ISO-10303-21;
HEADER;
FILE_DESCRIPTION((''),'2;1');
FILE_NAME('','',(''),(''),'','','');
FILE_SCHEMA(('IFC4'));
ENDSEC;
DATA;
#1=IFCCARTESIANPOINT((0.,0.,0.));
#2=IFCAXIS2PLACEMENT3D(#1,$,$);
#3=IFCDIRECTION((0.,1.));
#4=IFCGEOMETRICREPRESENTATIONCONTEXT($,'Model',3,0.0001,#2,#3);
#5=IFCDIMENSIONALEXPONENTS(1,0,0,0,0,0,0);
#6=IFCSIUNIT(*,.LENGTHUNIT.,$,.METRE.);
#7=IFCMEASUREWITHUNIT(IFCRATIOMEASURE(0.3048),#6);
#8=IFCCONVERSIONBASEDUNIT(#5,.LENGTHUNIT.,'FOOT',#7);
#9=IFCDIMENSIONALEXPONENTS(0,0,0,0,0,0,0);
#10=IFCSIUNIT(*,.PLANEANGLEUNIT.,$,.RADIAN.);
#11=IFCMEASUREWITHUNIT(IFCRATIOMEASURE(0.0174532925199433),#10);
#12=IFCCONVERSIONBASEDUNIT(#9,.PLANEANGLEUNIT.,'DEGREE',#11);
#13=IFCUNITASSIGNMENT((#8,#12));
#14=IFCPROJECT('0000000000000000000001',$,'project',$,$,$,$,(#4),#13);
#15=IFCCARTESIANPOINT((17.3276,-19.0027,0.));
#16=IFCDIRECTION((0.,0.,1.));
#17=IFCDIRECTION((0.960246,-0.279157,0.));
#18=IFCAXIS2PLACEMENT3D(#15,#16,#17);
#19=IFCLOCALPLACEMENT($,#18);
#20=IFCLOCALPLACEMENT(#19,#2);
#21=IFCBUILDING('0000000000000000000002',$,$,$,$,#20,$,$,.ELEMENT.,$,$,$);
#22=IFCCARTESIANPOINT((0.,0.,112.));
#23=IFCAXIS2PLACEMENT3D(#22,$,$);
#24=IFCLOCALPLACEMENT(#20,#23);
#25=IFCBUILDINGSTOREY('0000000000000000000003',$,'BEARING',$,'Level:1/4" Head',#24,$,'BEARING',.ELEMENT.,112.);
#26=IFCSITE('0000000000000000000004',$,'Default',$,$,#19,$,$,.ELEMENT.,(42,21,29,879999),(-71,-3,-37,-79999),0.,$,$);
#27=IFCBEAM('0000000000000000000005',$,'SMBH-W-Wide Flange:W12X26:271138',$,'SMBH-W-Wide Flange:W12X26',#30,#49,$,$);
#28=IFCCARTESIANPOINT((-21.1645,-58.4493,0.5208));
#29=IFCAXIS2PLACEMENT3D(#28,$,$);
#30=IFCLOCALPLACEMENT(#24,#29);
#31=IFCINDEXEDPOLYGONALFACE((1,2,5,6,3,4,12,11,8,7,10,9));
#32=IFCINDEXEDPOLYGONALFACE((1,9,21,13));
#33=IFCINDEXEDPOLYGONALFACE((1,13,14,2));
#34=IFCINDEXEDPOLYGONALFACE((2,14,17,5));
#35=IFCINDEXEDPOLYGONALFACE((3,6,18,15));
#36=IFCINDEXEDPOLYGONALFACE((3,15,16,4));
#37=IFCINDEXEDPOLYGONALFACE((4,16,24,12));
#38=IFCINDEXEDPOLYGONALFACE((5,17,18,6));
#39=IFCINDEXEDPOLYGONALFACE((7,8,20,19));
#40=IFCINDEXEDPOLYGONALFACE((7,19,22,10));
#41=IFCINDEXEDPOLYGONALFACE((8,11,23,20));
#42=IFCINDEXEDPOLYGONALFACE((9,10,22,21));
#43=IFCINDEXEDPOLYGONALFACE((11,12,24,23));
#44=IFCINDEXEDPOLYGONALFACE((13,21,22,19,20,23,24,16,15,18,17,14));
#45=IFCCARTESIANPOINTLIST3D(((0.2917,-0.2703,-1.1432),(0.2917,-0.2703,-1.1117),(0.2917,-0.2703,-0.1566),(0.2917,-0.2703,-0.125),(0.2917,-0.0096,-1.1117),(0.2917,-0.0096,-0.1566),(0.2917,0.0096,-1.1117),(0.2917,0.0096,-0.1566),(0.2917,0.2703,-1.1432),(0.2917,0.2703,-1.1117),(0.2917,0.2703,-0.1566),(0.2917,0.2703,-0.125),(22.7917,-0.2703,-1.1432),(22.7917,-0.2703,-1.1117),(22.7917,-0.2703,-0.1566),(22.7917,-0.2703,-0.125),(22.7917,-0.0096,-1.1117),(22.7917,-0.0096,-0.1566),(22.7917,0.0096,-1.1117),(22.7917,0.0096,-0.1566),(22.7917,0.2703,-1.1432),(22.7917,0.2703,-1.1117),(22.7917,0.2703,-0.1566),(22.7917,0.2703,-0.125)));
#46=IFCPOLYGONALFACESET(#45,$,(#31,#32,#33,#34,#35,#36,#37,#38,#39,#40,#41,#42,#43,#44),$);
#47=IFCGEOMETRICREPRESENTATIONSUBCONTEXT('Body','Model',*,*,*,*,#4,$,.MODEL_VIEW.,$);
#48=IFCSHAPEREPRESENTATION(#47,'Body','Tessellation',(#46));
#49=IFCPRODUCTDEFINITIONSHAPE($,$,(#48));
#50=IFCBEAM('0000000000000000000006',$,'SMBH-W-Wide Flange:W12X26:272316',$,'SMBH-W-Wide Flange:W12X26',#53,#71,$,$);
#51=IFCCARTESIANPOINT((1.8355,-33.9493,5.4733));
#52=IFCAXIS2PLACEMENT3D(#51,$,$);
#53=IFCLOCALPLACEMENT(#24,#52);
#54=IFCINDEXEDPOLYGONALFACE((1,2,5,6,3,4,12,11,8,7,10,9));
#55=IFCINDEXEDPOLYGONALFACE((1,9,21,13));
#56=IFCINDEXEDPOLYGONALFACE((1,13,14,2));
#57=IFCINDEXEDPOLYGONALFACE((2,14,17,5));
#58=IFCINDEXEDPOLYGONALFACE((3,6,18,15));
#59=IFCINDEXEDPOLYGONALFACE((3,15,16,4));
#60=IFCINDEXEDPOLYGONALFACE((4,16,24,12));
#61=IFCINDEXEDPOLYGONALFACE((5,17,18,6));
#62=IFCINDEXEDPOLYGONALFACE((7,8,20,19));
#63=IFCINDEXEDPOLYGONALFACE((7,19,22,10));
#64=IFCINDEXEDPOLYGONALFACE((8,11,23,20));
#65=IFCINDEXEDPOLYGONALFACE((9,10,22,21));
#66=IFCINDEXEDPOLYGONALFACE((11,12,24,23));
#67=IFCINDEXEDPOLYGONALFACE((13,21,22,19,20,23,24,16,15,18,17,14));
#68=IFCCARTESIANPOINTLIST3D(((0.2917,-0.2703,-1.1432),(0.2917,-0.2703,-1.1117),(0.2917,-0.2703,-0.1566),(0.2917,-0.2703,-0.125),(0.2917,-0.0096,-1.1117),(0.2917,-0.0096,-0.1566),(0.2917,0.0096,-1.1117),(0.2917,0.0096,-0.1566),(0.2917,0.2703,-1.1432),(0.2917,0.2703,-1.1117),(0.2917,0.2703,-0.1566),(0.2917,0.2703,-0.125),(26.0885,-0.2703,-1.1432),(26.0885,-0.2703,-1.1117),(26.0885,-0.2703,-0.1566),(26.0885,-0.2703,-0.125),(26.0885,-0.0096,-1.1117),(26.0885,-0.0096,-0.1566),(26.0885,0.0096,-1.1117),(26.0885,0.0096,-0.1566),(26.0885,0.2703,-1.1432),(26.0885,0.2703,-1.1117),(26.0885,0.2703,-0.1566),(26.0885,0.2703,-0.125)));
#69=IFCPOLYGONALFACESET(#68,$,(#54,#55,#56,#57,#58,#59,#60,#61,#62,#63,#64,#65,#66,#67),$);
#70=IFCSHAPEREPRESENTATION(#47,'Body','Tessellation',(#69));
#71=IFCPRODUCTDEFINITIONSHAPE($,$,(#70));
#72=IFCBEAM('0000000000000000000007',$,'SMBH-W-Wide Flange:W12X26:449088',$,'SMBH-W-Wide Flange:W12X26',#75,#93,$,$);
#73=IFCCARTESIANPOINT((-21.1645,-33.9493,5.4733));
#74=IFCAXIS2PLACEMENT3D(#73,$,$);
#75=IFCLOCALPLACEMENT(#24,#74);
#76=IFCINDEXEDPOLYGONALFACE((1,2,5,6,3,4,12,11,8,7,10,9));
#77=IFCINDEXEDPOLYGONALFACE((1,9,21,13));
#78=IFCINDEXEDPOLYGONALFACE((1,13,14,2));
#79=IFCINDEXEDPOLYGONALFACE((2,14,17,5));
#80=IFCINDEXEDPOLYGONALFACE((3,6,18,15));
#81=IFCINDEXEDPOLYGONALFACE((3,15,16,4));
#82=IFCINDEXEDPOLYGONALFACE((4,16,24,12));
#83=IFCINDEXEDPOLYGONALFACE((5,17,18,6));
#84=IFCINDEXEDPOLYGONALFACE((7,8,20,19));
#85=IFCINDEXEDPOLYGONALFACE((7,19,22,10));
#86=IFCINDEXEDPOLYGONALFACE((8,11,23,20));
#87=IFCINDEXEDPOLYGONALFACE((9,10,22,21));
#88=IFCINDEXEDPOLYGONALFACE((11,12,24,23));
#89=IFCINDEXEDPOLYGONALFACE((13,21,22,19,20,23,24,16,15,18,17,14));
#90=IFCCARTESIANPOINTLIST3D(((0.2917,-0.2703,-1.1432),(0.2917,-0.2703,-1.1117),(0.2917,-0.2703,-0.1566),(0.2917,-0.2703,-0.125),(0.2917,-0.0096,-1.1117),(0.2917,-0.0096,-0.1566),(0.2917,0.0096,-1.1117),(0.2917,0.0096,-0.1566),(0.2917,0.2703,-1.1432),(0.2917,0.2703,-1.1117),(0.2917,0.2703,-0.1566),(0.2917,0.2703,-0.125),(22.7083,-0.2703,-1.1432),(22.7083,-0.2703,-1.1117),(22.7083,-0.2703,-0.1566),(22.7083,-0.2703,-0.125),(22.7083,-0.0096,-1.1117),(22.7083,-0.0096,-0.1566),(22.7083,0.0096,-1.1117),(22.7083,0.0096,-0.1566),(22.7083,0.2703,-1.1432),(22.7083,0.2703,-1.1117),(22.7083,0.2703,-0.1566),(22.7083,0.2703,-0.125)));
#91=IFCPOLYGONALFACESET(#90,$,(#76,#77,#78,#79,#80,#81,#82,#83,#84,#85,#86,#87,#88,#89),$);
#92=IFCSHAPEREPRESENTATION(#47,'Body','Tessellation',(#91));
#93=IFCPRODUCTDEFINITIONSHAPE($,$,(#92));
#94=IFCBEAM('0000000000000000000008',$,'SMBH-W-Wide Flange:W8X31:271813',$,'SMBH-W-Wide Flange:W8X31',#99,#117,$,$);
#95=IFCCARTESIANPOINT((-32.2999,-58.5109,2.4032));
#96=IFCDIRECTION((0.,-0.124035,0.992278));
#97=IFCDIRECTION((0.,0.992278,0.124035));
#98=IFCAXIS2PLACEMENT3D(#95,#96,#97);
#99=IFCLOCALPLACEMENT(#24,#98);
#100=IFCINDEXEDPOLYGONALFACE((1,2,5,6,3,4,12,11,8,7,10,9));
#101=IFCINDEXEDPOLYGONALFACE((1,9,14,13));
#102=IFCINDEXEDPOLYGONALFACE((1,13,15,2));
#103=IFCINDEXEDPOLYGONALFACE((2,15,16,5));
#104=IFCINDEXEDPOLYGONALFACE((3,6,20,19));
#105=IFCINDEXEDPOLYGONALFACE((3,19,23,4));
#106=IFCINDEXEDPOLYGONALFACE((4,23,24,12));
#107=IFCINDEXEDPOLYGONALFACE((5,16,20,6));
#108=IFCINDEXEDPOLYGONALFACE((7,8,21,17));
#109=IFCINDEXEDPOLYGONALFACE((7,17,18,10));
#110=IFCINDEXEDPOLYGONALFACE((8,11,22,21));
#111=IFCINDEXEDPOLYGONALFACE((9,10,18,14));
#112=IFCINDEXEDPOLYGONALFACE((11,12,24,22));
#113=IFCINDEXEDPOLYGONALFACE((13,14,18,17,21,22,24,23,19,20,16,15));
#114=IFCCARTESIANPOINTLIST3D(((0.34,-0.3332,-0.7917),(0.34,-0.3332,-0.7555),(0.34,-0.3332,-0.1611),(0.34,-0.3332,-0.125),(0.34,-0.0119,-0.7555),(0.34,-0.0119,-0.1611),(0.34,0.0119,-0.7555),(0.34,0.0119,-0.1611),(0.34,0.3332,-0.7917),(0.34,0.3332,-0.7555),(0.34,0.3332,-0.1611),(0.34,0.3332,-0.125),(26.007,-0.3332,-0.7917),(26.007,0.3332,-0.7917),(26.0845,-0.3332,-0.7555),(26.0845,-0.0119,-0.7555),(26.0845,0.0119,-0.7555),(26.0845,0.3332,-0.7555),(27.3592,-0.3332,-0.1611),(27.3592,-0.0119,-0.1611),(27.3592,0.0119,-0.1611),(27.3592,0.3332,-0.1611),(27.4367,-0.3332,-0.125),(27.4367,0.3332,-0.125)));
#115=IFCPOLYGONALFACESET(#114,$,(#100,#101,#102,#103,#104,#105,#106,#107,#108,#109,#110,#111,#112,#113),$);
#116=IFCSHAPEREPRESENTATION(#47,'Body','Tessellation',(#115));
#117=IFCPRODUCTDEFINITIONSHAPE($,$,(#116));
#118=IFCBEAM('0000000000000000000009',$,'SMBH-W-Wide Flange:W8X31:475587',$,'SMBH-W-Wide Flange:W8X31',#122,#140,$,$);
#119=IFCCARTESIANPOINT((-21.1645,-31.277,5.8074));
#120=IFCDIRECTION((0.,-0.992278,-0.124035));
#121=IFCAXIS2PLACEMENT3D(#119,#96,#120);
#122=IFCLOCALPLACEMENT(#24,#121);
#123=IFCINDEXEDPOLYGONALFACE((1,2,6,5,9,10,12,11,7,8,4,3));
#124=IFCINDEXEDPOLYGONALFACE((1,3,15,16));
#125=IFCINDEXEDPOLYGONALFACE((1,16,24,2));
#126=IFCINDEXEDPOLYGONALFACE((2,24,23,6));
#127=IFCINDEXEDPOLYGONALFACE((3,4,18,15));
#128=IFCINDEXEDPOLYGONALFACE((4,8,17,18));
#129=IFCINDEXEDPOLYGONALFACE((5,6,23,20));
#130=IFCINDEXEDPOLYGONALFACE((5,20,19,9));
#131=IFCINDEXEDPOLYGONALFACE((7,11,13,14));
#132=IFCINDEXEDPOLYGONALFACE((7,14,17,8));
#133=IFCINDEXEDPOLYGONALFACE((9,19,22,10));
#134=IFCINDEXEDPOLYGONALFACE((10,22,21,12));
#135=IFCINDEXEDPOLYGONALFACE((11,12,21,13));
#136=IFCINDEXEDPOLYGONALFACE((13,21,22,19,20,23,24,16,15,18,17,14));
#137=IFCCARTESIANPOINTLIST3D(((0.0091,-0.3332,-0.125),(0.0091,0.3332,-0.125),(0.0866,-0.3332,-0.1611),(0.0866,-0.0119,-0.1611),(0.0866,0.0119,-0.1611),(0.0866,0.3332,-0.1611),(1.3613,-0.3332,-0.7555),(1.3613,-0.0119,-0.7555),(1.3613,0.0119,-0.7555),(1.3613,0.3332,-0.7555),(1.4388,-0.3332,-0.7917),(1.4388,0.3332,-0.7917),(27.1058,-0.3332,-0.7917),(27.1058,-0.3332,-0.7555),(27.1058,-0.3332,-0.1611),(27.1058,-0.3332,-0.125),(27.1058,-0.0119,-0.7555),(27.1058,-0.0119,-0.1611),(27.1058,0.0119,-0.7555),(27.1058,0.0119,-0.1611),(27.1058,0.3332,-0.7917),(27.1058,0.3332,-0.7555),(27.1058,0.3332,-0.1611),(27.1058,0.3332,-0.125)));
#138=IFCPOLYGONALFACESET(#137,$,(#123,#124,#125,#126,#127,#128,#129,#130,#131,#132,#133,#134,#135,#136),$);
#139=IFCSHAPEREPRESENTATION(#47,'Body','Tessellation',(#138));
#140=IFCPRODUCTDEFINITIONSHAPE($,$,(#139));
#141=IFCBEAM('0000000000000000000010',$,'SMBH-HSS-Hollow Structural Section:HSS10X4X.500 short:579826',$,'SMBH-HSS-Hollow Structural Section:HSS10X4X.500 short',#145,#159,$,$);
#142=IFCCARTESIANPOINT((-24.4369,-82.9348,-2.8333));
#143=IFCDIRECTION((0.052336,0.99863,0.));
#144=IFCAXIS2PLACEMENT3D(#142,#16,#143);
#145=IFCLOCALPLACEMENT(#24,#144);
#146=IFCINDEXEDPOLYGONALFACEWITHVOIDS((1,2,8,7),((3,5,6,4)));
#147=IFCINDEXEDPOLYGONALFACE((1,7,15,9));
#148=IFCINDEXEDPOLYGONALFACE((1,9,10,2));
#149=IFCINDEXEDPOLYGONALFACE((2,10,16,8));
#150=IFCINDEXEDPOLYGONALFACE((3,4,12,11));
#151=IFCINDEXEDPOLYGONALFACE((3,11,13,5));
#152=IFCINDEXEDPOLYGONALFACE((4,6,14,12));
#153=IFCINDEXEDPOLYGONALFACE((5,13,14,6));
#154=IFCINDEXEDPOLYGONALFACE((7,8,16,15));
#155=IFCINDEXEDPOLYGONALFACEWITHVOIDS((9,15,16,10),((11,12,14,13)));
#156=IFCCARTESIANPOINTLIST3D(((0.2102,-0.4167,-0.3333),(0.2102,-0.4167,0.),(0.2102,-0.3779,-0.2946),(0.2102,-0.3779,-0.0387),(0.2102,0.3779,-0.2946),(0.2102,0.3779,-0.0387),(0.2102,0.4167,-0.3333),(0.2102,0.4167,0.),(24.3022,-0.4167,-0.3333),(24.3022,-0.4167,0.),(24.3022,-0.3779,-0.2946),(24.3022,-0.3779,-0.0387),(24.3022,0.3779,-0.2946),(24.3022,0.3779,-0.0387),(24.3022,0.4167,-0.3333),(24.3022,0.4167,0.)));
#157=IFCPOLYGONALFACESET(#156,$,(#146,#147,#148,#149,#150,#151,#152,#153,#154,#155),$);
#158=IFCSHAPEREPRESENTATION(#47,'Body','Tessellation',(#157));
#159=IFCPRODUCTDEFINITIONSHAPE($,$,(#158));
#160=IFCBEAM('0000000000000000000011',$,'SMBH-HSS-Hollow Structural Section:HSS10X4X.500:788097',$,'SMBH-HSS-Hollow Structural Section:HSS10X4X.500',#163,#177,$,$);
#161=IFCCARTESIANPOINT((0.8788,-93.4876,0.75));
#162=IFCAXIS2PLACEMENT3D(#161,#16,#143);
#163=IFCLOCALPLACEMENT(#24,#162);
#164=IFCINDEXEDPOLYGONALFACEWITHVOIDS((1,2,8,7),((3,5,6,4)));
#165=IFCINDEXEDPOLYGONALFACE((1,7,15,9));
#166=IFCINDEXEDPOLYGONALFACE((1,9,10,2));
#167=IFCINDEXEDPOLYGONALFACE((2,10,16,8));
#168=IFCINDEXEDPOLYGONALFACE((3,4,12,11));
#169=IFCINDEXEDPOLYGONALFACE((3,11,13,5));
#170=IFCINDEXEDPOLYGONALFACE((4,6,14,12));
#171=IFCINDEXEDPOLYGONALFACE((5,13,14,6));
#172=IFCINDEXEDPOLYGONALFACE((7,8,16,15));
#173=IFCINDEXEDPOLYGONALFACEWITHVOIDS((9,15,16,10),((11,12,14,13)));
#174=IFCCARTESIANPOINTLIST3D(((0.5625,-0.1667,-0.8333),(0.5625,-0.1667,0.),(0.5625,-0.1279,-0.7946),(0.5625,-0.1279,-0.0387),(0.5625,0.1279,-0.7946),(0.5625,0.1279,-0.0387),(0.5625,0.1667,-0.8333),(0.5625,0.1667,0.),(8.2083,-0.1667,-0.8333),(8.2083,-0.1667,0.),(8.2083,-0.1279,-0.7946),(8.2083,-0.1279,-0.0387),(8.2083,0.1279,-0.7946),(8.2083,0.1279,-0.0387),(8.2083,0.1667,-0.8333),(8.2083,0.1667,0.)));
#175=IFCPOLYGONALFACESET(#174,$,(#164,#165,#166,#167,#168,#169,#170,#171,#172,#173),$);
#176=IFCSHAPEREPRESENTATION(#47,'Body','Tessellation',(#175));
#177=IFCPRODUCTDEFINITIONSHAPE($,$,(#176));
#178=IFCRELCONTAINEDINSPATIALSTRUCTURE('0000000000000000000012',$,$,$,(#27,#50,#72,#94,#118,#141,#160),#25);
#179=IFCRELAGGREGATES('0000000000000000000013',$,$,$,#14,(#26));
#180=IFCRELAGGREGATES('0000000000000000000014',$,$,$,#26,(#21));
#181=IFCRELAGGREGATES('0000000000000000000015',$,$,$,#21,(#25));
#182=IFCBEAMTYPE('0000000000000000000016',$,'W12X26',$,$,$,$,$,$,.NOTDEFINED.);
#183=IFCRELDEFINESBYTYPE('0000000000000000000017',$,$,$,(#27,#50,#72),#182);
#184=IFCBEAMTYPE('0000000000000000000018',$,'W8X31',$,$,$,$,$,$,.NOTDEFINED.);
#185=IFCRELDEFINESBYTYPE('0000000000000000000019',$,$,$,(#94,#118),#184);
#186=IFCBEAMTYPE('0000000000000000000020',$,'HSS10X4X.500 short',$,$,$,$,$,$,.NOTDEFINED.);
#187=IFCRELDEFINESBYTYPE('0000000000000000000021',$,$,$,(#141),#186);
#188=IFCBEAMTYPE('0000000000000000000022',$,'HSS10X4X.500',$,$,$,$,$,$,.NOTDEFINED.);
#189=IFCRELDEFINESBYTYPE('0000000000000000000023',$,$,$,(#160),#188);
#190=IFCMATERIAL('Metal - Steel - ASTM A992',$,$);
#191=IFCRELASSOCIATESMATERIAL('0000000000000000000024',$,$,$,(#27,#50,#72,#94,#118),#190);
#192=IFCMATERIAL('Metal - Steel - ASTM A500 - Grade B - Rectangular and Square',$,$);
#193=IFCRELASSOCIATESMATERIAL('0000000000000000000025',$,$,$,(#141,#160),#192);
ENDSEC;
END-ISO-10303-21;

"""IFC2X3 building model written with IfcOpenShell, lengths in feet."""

from ifc_helpers import new_model, entity, si_unit, converted_unit, direction, frame, frame_2d, origin, place, context, subcontext, project, spatial, rectangle, i_section, extrude, boolean, clip, halfspace, material, type_object, element, save


model = new_model("IFC2X3")

# Units and contexts
model_context = context("Model", 3, precision=0.0001, world=origin(), true_north=direction((0.0, 1.0)))
body_context = subcontext(model_context, "Body", "Model", "MODEL_VIEW")
ifc_project = project(units=[converted_unit("LENGTHUNIT", "FOOT", entity("IfcRatioMeasure", 0.3048), si_unit("LENGTHUNIT", "METRE"), dimensions=[1, 0, 0, 0, 0, 0, 0]), converted_unit("PLANEANGLEUNIT", "DEGREE", entity("IfcRatioMeasure", 0.0174532925199433), si_unit("PLANEANGLEUNIT", "RADIAN"), dimensions=[0, 0, 0, 0, 0, 0, 0])], contexts=[model_context])

# Site, building, storey
site_placement = place(None, frame((17.3276, -19.0027, 0.0), z_axis=(0.0, 0.0, 1.0), x_axis=(0.960246, -0.279157, 0.0)))
site = spatial("IfcSite", under=ifc_project, at=site_placement, Name="Default", CompositionType="ELEMENT", RefLatitude=(42, 21, 29, 879999), RefLongitude=(-71, -3, -37, -79999), RefElevation=0.0)
building_placement = place(site_placement, origin())
building = spatial("IfcBuilding", under=site, at=building_placement, CompositionType="ELEMENT")
storey_placement = place(building_placement, frame((0.0, 0.0, 112.0)))
storey = spatial("IfcBuildingStorey", under=building, at=storey_placement, Name="BEARING", ObjectType="Level:1/4\" Head", LongName="BEARING", CompositionType="ELEMENT", Elevation=112.0)

# Shared definitions
ifc_material_1 = material(Name="Metal - Steel - ASTM A500 - Grade B - Rectangular and Square")

# Beams
ifc_material_2 = material(Name="Metal - Steel - ASTM A992")
beam_type_1 = type_object("IfcBeamType", Name="W12X26", PredefinedType="NOTDEFINED")
beam_1_placement = place(storey_placement, frame((-21.1645, -58.4493, 0.5208)))
element("IfcBeam", 1, at=beam_1_placement, inside=storey, type_object=beam_type_1, material=ifc_material_2, Name="SMBH-W-Wide Flange:W12X26:271138", ObjectType="SMBH-W-Wide Flange:W12X26", context=body_context, shape_type="SweptSolid", body=[
    extrude(i_section(OverallWidth=0.5407, OverallDepth=1.0182, WebThickness=0.0192, FlangeThickness=0.0316, at=frame_2d((0.0, 0.0), x_axis=(0.0, 1.0))), frame((0.2917, 0.0, -0.6341), z_axis=(1.0, 0.0, 0.0), x_axis=(0.0, 0.0, -1.0)), (0.0, 0.0, 1.0), 22.5),
])
beam_2_placement = place(storey_placement, frame((1.8355, -33.9493, 5.4733)))
element("IfcBeam", 2, at=beam_2_placement, inside=storey, type_object=beam_type_1, material=ifc_material_2, Name="SMBH-W-Wide Flange:W12X26:272316", ObjectType="SMBH-W-Wide Flange:W12X26", context=body_context, shape_type="SweptSolid", body=[
    extrude(i_section(OverallWidth=0.5407, OverallDepth=1.0182, WebThickness=0.0192, FlangeThickness=0.0316, at=frame_2d((0.0, 0.0), x_axis=(0.0, 1.0))), frame((0.2917, 0.0, -0.6341), z_axis=(1.0, 0.0, 0.0), x_axis=(0.0, 0.0, -1.0)), (0.0, 0.0, 1.0), 25.7969),
])
beam_3_placement = place(storey_placement, frame((-21.1645, -33.9493, 5.4733)))
element("IfcBeam", 3, at=beam_3_placement, inside=storey, type_object=beam_type_1, material=ifc_material_2, Name="SMBH-W-Wide Flange:W12X26:449088", ObjectType="SMBH-W-Wide Flange:W12X26", context=body_context, shape_type="SweptSolid", body=[
    extrude(i_section(OverallWidth=0.5407, OverallDepth=1.0182, WebThickness=0.0192, FlangeThickness=0.0316, at=frame_2d((0.0, 0.0), x_axis=(0.0, 1.0))), frame((0.2917, 0.0, -0.6341), z_axis=(1.0, 0.0, 0.0), x_axis=(0.0, 0.0, -1.0)), (0.0, 0.0, 1.0), 22.4167),
])
beam_type_2 = type_object("IfcBeamType", Name="W8X31", PredefinedType="NOTDEFINED")
beam_4_placement = place(storey_placement, frame((-32.2999, -58.5109, 2.4032), z_axis=(0.0, -0.124035, 0.992278), x_axis=(0.0, 0.992278, 0.124035)))
element("IfcBeam", 4, at=beam_4_placement, inside=storey, type_object=beam_type_2, material=ifc_material_2, Name="SMBH-W-Wide Flange:W8X31:271813", ObjectType="SMBH-W-Wide Flange:W8X31", context=body_context, shape_type="SweptSolid", body=[
    clip(extrude(i_section(OverallWidth=0.6663, OverallDepth=0.6667, WebThickness=0.0238, FlangeThickness=0.0361, at=frame_2d((0.0, 0.0), x_axis=(0.0, 1.0))), frame((0.34, 0.0, -0.4583), z_axis=(1.0, 0.0, 0.0), x_axis=(0.0, 0.0, -1.0)), (0.0, 0.0, 1.0), 27.0967), halfspace(frame((27.4367, -27.5508, -0.125), z_axis=(0.422618, 0.0, -0.906308), x_axis=(0.0, 1.0, 0.0)), False)),
])
beam_5_placement = place(storey_placement, frame((-21.1645, -31.277, 5.8074), z_axis=(0.0, -0.124035, 0.992278), x_axis=(0.0, -0.992278, -0.124035)))
element("IfcBeam", 5, at=beam_5_placement, inside=storey, type_object=beam_type_2, material=ifc_material_2, Name="SMBH-W-Wide Flange:W8X31:475587", ObjectType="SMBH-W-Wide Flange:W8X31", context=body_context, shape_type="SweptSolid", body=[
    clip(extrude(i_section(OverallWidth=0.6663, OverallDepth=0.6667, WebThickness=0.0238, FlangeThickness=0.0361, at=frame_2d((0.0, 0.0), x_axis=(0.0, 1.0))), frame((0.0091, 0.0, -0.4583), z_axis=(1.0, 0.0, 0.0), x_axis=(0.0, 0.0, -1.0)), (0.0, 0.0, 1.0), 27.0967), halfspace(frame((1.4388, -27.4671, -0.7917), z_axis=(-0.422618, 0.0, -0.906308), x_axis=(0.0, 1.0, 0.0)), False)),
])
beam_type_3 = type_object("IfcBeamType", Name="HSS10X4X.500 short", PredefinedType="NOTDEFINED")
beam_6_placement = place(storey_placement, frame((-24.4369, -82.9348, -2.8333), z_axis=(0.0, 0.0, 1.0), x_axis=(0.052336, 0.99863, 0.0)))
element("IfcBeam", 6, at=beam_6_placement, inside=storey, type_object=beam_type_3, material=ifc_material_1, Name="SMBH-HSS-Hollow Structural Section:HSS10X4X.500 short:579826", ObjectType="SMBH-HSS-Hollow Structural Section:HSS10X4X.500 short", context=body_context, shape_type="SweptSolid", body=[
    boolean("DIFFERENCE", extrude(rectangle(XDim=0.3333, YDim=0.8333, at=frame_2d((0.0, 0.0), x_axis=(1.0, 0.0))), frame((0.2102, 0.0, -0.1667), z_axis=(1.0, 0.0, 0.0), x_axis=(0.0, 0.0, -1.0)), (0.0, 0.0, 1.0), 24.092), extrude(rectangle(XDim=0.2559, YDim=0.7559, at=frame_2d((0.0, 0.0), x_axis=(0.0, 1.0))), frame((24.3022, 0.0, -0.1667), z_axis=(-1.0, 0.0, 0.0), x_axis=(0.0, 1.0, 0.0)), (0.0, 0.0, 1.0), 24.092)),
])

# Beam
beam_type_4 = type_object("IfcBeamType", Name="HSS10X4X.500", PredefinedType="NOTDEFINED")
beam_7_placement = place(storey_placement, frame((0.8788, -93.4876, 0.75), z_axis=(0.0, 0.0, 1.0), x_axis=(0.052336, 0.99863, 0.0)))
element("IfcBeam", 7, at=beam_7_placement, inside=storey, type_object=beam_type_4, material=ifc_material_1, Name="SMBH-HSS-Hollow Structural Section:HSS10X4X.500:788097", ObjectType="SMBH-HSS-Hollow Structural Section:HSS10X4X.500", context=body_context, shape_type="SweptSolid", body=[
    boolean("DIFFERENCE", extrude(rectangle(XDim=0.8333, YDim=0.3333, at=frame_2d((0.0, 0.0), x_axis=(1.0, 0.0))), frame((0.5625, 0.0, -0.4167), z_axis=(1.0, 0.0, 0.0), x_axis=(0.0, 0.0, -1.0)), (0.0, 0.0, 1.0), 7.6458), extrude(rectangle(XDim=0.7559, YDim=0.2559, at=frame_2d((0.0, 0.0), x_axis=(0.0, 1.0))), frame((8.2083, 0.0, -0.4167), z_axis=(-1.0, 0.0, 0.0), x_axis=(0.0, 1.0, 0.0)), (0.0, 0.0, 1.0), 7.6458)),
])

save(model, "model.ifc")
